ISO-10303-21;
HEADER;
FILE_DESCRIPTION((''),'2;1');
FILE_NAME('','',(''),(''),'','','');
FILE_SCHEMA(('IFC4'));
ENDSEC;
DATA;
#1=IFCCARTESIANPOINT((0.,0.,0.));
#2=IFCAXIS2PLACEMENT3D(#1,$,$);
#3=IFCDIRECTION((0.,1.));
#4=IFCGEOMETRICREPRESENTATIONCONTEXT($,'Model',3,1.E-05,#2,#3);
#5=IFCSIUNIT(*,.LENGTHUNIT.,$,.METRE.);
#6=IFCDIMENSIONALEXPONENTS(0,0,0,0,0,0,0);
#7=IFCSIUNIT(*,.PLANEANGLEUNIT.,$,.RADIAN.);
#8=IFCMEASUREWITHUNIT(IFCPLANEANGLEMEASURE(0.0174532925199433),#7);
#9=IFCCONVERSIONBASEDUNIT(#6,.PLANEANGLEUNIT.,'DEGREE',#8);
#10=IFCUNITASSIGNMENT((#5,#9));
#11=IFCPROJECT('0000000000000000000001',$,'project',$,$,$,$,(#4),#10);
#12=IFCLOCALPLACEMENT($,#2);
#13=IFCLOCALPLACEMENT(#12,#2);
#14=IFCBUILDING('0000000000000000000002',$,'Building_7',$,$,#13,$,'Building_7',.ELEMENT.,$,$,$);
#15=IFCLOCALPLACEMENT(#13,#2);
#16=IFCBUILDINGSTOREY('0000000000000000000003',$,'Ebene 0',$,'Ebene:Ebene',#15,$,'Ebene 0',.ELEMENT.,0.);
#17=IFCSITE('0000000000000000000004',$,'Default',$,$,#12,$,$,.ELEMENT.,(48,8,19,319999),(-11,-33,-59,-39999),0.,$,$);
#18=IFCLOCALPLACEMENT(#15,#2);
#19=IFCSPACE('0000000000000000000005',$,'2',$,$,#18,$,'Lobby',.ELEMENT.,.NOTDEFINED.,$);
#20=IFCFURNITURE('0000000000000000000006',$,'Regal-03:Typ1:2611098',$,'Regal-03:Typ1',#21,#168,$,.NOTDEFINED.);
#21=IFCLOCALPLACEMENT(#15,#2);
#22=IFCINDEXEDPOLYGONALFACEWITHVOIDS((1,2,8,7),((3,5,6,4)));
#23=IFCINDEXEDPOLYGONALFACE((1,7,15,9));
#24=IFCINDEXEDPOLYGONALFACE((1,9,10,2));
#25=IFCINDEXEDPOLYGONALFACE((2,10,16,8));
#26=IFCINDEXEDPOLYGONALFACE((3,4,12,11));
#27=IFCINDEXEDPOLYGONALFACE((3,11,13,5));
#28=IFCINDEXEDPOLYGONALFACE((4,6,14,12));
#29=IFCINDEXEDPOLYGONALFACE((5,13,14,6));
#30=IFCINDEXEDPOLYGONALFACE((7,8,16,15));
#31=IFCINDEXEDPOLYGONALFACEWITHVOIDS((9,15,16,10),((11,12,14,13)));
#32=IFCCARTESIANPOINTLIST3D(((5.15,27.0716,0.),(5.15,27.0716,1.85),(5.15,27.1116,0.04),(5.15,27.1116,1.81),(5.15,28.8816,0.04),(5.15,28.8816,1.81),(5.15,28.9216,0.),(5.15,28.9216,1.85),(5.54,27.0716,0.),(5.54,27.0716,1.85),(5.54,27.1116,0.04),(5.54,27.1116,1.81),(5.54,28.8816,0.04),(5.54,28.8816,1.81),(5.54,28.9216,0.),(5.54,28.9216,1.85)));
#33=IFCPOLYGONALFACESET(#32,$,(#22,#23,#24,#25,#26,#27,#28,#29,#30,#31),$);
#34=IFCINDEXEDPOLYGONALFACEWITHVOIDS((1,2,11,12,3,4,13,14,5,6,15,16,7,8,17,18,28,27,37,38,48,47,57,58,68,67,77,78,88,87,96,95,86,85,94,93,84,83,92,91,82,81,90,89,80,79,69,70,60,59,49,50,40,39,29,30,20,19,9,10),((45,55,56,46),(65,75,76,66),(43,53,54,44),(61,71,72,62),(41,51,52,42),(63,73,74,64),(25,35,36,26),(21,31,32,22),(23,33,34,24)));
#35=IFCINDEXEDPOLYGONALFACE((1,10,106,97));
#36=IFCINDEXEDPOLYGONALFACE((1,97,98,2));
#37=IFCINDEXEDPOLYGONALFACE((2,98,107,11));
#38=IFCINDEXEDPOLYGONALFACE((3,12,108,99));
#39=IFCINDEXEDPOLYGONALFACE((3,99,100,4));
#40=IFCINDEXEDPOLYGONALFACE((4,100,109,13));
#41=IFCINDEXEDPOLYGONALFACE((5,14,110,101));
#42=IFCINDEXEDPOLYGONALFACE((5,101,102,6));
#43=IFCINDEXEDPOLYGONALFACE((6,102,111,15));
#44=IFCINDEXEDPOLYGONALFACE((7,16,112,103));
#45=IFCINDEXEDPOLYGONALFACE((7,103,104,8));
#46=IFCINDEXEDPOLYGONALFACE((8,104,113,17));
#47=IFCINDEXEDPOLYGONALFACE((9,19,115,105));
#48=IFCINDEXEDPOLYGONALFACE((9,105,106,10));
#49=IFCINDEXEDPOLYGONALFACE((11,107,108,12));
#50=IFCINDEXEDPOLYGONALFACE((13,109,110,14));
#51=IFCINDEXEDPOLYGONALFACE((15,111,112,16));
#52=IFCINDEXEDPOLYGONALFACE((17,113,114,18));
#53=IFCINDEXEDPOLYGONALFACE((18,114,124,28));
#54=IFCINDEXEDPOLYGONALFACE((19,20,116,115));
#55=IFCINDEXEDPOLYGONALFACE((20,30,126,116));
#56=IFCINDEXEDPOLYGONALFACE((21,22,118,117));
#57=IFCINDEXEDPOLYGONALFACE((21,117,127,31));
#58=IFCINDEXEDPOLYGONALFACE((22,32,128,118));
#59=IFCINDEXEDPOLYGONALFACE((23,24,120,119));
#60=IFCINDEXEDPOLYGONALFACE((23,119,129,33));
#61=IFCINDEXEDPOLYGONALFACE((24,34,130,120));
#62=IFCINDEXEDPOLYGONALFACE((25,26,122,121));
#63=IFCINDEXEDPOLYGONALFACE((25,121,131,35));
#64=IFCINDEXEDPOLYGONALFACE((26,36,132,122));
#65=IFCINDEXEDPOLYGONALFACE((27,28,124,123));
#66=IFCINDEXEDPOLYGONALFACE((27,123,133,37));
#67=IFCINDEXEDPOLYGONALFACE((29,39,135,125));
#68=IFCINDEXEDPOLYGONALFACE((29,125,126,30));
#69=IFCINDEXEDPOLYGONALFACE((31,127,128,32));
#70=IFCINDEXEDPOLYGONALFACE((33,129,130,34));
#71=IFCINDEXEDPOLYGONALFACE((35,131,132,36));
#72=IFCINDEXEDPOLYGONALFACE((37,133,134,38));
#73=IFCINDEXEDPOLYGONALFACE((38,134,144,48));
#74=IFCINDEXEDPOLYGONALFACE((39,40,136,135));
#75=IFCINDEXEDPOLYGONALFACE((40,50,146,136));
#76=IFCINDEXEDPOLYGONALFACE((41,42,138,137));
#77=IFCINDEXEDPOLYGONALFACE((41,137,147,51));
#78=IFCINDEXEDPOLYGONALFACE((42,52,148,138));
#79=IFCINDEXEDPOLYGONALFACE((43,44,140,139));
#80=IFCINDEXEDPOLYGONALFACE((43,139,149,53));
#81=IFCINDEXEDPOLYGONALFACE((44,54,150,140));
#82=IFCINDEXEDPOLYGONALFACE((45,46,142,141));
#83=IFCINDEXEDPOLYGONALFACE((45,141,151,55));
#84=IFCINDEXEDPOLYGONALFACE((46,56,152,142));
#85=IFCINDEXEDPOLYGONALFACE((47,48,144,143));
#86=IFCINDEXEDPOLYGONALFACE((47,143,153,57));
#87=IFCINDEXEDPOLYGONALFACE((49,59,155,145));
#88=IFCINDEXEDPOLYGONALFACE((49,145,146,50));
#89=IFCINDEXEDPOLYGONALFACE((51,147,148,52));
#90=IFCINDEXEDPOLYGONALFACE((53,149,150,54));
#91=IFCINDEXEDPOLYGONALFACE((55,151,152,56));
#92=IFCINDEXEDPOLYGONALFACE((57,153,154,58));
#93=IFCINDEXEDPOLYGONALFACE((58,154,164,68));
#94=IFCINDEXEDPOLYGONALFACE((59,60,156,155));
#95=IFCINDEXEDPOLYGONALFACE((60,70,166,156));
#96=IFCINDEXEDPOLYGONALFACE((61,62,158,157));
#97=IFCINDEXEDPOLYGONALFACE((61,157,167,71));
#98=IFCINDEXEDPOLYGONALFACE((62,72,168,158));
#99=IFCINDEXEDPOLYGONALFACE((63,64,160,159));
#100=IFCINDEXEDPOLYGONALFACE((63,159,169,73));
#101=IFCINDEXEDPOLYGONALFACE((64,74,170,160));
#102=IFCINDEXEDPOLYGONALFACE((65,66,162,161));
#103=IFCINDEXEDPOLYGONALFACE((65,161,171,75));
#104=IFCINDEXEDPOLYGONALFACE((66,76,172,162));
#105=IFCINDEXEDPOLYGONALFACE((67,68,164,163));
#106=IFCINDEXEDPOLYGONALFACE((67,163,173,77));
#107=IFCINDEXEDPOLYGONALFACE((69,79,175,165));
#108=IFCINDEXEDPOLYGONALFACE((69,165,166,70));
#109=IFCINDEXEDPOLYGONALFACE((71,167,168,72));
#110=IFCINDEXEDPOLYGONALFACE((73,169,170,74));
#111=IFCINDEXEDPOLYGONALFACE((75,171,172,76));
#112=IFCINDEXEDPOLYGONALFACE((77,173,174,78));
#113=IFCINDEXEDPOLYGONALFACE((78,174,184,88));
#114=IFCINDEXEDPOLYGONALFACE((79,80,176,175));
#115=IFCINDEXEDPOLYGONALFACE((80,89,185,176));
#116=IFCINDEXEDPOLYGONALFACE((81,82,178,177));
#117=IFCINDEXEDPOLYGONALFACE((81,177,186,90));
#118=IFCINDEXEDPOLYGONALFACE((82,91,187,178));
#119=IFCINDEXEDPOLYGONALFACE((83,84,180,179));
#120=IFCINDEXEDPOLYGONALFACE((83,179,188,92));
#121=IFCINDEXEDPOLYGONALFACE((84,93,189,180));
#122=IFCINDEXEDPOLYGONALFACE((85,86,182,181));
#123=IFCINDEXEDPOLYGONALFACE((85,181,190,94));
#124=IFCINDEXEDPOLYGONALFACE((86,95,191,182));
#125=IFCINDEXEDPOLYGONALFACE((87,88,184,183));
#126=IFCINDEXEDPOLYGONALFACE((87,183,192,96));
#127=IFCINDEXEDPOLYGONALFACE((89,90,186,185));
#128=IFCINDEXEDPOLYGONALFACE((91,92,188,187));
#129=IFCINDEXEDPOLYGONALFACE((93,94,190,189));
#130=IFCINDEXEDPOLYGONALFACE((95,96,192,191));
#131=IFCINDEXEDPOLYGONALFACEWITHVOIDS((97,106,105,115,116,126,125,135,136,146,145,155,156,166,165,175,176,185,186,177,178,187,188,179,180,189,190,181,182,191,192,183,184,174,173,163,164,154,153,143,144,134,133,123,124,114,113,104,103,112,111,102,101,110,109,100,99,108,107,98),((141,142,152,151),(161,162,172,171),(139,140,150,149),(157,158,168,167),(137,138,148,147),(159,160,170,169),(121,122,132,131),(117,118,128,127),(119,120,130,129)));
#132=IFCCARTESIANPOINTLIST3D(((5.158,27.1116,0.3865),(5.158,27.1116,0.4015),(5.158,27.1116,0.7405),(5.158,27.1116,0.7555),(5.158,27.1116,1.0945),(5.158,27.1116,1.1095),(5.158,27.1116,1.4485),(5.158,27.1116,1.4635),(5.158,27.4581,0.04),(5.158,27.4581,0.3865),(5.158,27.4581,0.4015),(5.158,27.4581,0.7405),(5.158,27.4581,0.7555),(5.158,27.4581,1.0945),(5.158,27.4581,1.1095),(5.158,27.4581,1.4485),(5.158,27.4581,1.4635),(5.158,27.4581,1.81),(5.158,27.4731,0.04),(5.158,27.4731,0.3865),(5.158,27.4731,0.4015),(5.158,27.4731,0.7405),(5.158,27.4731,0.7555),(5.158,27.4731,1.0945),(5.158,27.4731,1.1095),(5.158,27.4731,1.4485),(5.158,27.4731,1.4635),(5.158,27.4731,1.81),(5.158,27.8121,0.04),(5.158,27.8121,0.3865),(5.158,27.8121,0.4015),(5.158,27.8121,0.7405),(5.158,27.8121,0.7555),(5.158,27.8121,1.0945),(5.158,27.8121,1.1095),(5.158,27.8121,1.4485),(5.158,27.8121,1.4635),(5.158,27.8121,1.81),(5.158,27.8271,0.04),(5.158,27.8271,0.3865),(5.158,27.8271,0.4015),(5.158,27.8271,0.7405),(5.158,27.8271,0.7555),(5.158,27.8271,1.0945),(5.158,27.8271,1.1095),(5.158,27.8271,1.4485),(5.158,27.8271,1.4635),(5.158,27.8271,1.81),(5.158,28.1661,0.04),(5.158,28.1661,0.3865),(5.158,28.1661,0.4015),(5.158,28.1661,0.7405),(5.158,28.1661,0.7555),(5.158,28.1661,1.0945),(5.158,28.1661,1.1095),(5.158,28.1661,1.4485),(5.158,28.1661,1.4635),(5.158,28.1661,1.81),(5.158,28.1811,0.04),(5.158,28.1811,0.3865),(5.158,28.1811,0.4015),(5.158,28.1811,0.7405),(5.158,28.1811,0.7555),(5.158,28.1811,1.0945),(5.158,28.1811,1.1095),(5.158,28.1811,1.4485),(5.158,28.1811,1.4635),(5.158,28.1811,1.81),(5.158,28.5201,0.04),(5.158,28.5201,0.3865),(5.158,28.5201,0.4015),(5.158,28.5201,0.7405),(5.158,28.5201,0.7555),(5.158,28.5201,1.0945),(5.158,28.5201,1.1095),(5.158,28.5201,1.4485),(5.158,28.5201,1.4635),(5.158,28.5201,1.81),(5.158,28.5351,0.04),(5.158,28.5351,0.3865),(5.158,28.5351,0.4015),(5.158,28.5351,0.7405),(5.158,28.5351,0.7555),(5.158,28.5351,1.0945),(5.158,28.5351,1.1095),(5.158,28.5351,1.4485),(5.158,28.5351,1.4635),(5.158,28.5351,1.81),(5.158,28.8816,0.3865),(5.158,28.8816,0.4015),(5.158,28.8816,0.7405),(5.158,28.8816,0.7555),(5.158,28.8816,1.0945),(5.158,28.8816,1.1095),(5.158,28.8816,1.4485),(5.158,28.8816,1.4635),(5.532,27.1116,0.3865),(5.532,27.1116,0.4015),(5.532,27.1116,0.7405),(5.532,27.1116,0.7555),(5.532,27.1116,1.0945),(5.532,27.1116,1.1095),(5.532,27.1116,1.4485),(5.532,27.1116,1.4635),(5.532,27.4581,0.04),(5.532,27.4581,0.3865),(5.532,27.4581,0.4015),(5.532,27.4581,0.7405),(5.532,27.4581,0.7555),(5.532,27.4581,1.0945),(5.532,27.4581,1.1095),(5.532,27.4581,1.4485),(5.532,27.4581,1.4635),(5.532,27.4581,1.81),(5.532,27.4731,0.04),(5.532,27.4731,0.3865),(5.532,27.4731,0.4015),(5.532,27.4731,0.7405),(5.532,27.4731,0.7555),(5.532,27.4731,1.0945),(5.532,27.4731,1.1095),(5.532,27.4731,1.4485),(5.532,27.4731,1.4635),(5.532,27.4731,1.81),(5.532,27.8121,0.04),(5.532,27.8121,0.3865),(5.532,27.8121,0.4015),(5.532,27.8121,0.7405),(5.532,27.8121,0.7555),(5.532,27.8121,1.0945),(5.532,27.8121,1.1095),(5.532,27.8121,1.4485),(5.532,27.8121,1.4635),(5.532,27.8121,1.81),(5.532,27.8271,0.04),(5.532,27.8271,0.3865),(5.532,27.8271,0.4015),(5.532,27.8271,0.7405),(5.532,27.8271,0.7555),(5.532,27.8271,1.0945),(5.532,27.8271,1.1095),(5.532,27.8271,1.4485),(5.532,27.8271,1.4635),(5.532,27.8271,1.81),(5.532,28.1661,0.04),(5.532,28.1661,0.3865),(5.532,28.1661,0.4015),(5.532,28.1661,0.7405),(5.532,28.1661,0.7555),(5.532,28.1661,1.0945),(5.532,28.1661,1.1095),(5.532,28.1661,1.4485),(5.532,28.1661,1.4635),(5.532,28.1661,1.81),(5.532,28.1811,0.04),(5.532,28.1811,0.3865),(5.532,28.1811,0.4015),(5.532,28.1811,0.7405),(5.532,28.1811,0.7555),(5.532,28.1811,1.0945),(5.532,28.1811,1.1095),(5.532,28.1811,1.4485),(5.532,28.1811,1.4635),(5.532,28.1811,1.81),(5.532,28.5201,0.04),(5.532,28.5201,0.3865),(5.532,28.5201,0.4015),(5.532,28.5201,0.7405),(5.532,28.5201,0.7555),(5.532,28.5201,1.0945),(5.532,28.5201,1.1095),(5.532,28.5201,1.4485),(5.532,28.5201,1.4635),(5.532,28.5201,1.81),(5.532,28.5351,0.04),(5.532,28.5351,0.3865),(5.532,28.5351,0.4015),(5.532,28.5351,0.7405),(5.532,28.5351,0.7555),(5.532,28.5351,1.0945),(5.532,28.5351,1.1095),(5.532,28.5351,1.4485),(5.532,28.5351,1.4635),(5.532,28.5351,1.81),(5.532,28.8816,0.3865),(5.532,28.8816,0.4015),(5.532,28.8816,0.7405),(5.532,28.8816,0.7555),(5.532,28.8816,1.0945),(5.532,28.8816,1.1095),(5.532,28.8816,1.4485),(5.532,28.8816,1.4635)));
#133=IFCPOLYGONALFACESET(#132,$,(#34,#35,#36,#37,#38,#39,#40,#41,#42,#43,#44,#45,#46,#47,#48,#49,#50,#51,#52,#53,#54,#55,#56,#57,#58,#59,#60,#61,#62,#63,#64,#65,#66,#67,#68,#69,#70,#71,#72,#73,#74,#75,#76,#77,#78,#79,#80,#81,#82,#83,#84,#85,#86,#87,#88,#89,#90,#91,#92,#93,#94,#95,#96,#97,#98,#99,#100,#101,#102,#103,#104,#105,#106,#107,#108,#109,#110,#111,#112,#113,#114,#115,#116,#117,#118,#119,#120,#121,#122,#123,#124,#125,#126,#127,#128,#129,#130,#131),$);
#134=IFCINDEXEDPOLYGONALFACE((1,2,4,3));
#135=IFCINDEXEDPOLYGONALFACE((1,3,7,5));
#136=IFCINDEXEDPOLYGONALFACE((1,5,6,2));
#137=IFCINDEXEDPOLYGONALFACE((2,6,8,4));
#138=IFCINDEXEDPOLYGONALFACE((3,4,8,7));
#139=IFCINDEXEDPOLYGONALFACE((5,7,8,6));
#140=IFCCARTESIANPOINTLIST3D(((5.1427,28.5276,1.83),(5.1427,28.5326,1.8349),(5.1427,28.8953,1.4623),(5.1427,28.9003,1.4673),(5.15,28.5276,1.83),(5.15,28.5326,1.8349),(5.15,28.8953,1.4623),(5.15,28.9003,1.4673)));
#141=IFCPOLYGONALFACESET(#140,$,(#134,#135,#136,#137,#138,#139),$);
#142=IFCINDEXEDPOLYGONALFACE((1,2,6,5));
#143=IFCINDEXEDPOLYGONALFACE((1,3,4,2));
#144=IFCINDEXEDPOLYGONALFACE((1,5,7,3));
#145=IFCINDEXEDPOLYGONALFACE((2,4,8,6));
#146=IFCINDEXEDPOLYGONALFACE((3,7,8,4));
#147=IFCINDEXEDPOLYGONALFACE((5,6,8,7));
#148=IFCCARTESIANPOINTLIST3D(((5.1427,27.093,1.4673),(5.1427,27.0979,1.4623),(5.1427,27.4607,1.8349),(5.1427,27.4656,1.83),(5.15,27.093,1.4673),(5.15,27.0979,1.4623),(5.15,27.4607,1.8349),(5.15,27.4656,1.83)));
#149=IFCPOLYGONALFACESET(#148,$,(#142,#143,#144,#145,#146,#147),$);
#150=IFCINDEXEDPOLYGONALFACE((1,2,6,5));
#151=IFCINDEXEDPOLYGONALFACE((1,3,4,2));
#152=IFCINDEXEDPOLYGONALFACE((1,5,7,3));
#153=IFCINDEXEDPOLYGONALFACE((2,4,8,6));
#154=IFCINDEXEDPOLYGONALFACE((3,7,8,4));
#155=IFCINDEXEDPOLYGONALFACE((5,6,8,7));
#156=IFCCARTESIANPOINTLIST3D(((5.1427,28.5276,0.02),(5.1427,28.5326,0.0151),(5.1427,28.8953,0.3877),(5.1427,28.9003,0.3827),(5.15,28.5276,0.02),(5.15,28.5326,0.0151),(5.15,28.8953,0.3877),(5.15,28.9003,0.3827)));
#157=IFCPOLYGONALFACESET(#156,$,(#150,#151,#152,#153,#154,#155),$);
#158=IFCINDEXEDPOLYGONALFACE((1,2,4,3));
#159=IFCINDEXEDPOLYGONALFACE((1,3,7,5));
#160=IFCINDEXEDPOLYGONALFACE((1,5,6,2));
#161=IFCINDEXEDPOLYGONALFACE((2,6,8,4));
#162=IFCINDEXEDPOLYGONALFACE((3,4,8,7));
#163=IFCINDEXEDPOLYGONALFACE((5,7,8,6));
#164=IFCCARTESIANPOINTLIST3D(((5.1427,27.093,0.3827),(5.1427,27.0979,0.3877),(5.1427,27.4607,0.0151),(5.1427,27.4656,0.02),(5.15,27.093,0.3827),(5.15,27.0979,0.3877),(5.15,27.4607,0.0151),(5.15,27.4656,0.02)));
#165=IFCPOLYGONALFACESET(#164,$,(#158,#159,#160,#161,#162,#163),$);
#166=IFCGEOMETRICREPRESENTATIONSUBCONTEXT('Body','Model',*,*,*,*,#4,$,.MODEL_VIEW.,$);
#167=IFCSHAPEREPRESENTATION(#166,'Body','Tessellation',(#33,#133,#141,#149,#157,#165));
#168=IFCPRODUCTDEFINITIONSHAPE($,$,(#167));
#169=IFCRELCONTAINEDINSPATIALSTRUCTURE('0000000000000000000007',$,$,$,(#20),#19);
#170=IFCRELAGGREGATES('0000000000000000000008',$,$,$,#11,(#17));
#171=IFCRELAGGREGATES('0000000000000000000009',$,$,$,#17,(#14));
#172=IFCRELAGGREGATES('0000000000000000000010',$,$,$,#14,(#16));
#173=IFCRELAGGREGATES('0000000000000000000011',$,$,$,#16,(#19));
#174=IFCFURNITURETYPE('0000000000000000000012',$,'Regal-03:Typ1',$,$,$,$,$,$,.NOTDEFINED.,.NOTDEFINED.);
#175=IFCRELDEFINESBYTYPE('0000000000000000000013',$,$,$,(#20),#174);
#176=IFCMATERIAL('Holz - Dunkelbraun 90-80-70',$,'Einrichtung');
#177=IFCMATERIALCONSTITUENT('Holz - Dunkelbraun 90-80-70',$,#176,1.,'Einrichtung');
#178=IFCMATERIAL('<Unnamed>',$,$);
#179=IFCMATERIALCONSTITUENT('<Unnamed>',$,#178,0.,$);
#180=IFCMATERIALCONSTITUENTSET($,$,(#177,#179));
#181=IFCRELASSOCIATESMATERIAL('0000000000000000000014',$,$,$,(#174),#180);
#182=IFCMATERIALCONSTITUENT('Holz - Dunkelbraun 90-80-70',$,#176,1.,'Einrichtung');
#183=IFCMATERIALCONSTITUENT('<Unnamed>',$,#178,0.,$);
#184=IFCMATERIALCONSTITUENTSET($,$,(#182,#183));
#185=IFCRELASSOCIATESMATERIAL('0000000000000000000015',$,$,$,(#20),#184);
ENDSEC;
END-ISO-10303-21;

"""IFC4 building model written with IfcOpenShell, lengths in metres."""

from ifc_helpers import new_model, entity, si_unit, converted_unit, direction, frame, origin, place, context, subcontext, project, spatial, indexed_curve, outline, extrude, source, transform, mapped, material, constituent, constituent_set, type_object, type_shapes, element, save


model = new_model("IFC4")

# Units and contexts
model_context = context("Model", 3, precision=1e-05, world=origin(), true_north=direction((0.0, 1.0)))
body_context = subcontext(model_context, "Body", "Model", "MODEL_VIEW")
ifc_project = project(units=[si_unit("LENGTHUNIT", "METRE"), converted_unit("PLANEANGLEUNIT", "DEGREE", entity("IfcPlaneAngleMeasure", 0.0174532925199433), si_unit("PLANEANGLEUNIT", "RADIAN"), dimensions=[0, 0, 0, 0, 0, 0, 0])], contexts=[model_context])

# Site, building, storey
site_placement = place(None, origin())
site = spatial("IfcSite", under=ifc_project, at=site_placement, Name="Default", CompositionType="ELEMENT", RefLatitude=(48, 8, 19, 319999), RefLongitude=(-11, -33, -59, -39999), RefElevation=0.0)
building_placement = place(site_placement, origin())
building = spatial("IfcBuilding", under=site, at=building_placement, Name="Building_7", LongName="Building_7", CompositionType="ELEMENT")
storey_placement = place(building_placement, origin())
storey = spatial("IfcBuildingStorey", under=building, at=storey_placement, Name="Ebene 0", ObjectType="Ebene:Ebene", LongName="Ebene 0", CompositionType="ELEMENT", Elevation=0.0)

# Shared definitions
ifc_material_1 = material(Name="<Unnamed>")

# Shared definitions
space_1_placement = place(storey_placement, origin())
space_1 = spatial("IfcSpace", under=storey, at=space_1_placement, Name="2", LongName="Lobby", CompositionType="ELEMENT", PredefinedType="NOTDEFINED")

# Shared definitions
ifc_material_2 = material(Name="Holz - Dunkelbraun 90-80-70", Category="Einrichtung")

# Furniture
ifc_constituent_1 = constituent(ifc_material_2, Name="Holz - Dunkelbraun 90-80-70", Category="Einrichtung", fraction=1.0)
ifc_constituent_2 = constituent(ifc_material_1, Name="<Unnamed>", fraction=0.0)
ifc_constituent_set_1 = constituent_set(constituents=[ifc_constituent_1, ifc_constituent_2])
furniture_type_1 = type_object("IfcFurnitureType", Name="Regal-03:Typ1", AssemblyPlace="NOTDEFINED", PredefinedType="NOTDEFINED", material=ifc_constituent_set_1)
shared_shape_1 = source(origin(), body_context, "Body", "SweptSolid", [
    extrude(outline(indexed_curve([(-0.925, -0.925), (0.925, -0.925), (0.925, 0.925), (-0.925, 0.925), (-0.925, -0.925)], self_intersect=False), holes=[indexed_curve([(-0.885, -0.885), (-0.885, 0.885), (0.885, 0.885), (0.885, -0.885), (-0.885, -0.885)], self_intersect=False)]), frame((0.2471, -0.2651, 0.925), z_axis=(0.0, 1.0, 0.0), x_axis=(0.0, 0.0, -1.0)), (0.0, 0.0, 1.0), 0.39),
    extrude(outline(indexed_curve([(0.5385, -0.5385), (0.885, -0.5385), (0.885, -0.5235), (0.5385, -0.5235), (0.5385, -0.1845), (0.885, -0.1845), (0.885, -0.1695), (0.5385, -0.1695), (0.5385, 0.1695), (0.885, 0.1695), (0.885, 0.1845), (0.5385, 0.1845), (0.5385, 0.5235), (0.885, 0.5235), (0.885, 0.5385), (0.5385, 0.5385), (0.5385, 0.885), (0.5235, 0.885), (0.5235, 0.5385), (0.1845, 0.5385), (0.1845, 0.885), (0.1695, 0.885), (0.1695, 0.5385), (-0.1695, 0.5385), (-0.1695, 0.885), (-0.1845, 0.885), (-0.1845, 0.5385), (-0.5235, 0.5385), (-0.5235, 0.885), (-0.5385, 0.885), (-0.5385, 0.5385), (-0.885, 0.5385), (-0.885, 0.5235), (-0.5385, 0.5235), (-0.5385, 0.1845), (-0.885, 0.1845), (-0.885, 0.1695), (-0.5385, 0.1695), (-0.5385, -0.1695), (-0.885, -0.1695), (-0.885, -0.1845), (-0.5385, -0.1845), (-0.5385, -0.5235), (-0.885, -0.5235), (-0.885, -0.5385), (-0.5385, -0.5385), (-0.5385, -0.885), (-0.5235, -0.885), (-0.5235, -0.5385), (-0.1845, -0.5385), (-0.1845, -0.885), (-0.1695, -0.885), (-0.1695, -0.5385), (0.1695, -0.5385), (0.1695, -0.885), (0.1845, -0.885), (0.1845, -0.5385), (0.5235, -0.5385), (0.5235, -0.885), (0.5385, -0.885), (0.5385, -0.5385)], self_intersect=False), holes=[indexed_curve([(0.5235, -0.1845), (0.5235, -0.5235), (0.1845, -0.5235), (0.1845, -0.1845), (0.5235, -0.1845)], self_intersect=False), indexed_curve([(0.1845, -0.1695), (0.1845, 0.1695), (0.5235, 0.1695), (0.5235, -0.1695), (0.1845, -0.1695)], self_intersect=False), indexed_curve([(0.1845, 0.1845), (0.1845, 0.5235), (0.5235, 0.5235), (0.5235, 0.1845), (0.1845, 0.1845)], self_intersect=False), indexed_curve([(-0.1695, 0.5235), (0.1695, 0.5235), (0.1695, 0.1845), (-0.1695, 0.1845), (-0.1695, 0.5235)], self_intersect=False), indexed_curve([(-0.1695, 0.1695), (0.1695, 0.1695), (0.1695, -0.1695), (-0.1695, -0.1695), (-0.1695, 0.1695)], self_intersect=False), indexed_curve([(-0.1695, -0.1845), (0.1695, -0.1845), (0.1695, -0.5235), (-0.1695, -0.5235), (-0.1695, -0.1845)], self_intersect=False), indexed_curve([(-0.5235, -0.5235), (-0.5235, -0.1845), (-0.1845, -0.1845), (-0.1845, -0.5235), (-0.5235, -0.5235)], self_intersect=False), indexed_curve([(-0.5235, -0.1695), (-0.5235, 0.1695), (-0.1845, 0.1695), (-0.1845, -0.1695), (-0.5235, -0.1695)], self_intersect=False), indexed_curve([(-0.5235, 0.1845), (-0.5235, 0.5235), (-0.1845, 0.5235), (-0.1845, 0.1845), (-0.5235, 0.1845)], self_intersect=False)]), frame((0.2471, -0.2571, 0.925), z_axis=(0.0, 1.0, 0.0), x_axis=(0.0, 0.0, 1.0)), (0.0, 0.0, 1.0), 0.374),
    extrude(outline(indexed_curve([(-0.0037, -0.0035), (0.0037, -0.0035), (0.0037, 0.0035), (-0.0037, 0.0035), (-0.0037, -0.0035)], self_intersect=False)), frame((1.1482, 0.1286, 1.4648), z_axis=(-0.707107, 0.0, 0.707107), x_axis=(0.0, 1.0, 0.0)), (0.0, 0.0, 1.0), 0.52),
    extrude(outline(indexed_curve([(-0.0037, -0.0035), (0.0037, -0.0035), (0.0037, 0.0035), (-0.0037, 0.0035), (-0.0037, -0.0035)], self_intersect=False)), frame((-0.6541, 0.1286, 1.4648), z_axis=(0.707107, 0.0, 0.707107), x_axis=(0.0, 1.0, 0.0)), (0.0, 0.0, 1.0), 0.52),
    extrude(outline(indexed_curve([(-0.0037, -0.0035), (0.0037, -0.0035), (0.0037, 0.0035), (-0.0037, 0.0035), (-0.0037, -0.0035)], self_intersect=False)), frame((0.7805, 0.1286, 0.0175), z_axis=(0.707107, 0.0, 0.707107), x_axis=(0.0, 1.0, 0.0)), (0.0, 0.0, 1.0), 0.52),
    extrude(outline(indexed_curve([(-0.0037, -0.0035), (0.0037, -0.0035), (0.0037, 0.0035), (-0.0037, 0.0035), (-0.0037, -0.0035)], self_intersect=False)), frame((-0.2864, 0.1286, 0.0175), z_axis=(-0.707107, 0.0, 0.707107), x_axis=(0.0, 1.0, 0.0)), (0.0, 0.0, 1.0), 0.52),
])
type_shapes(furniture_type_1, [shared_shape_1])
ifc_constituent_3 = constituent(ifc_material_2, Name="Holz - Dunkelbraun 90-80-70", Category="Einrichtung", fraction=1.0)
ifc_constituent_4 = constituent(ifc_material_1, Name="<Unnamed>", fraction=0.0)
ifc_constituent_set_2 = constituent_set(constituents=[ifc_constituent_3, ifc_constituent_4])
furniture_1_placement = place(space_1_placement, frame((5.2749, 27.7496, 0.0), z_axis=(0.0, 0.0, 1.0), x_axis=(0.0, 1.0, 0.0)))
element("IfcFurniture", 1, at=furniture_1_placement, inside=space_1, type_object=furniture_type_1, material=ifc_constituent_set_2, Name="Regal-03:Typ1:2611098", ObjectType="Regal-03:Typ1", PredefinedType="NOTDEFINED", context=body_context, shape_type="MappedRepresentation", body=[
    mapped(shared_shape_1, transform((0.0, 0.0, 0.0), scale=1.0)),
])

save(model, "model.ifc")
